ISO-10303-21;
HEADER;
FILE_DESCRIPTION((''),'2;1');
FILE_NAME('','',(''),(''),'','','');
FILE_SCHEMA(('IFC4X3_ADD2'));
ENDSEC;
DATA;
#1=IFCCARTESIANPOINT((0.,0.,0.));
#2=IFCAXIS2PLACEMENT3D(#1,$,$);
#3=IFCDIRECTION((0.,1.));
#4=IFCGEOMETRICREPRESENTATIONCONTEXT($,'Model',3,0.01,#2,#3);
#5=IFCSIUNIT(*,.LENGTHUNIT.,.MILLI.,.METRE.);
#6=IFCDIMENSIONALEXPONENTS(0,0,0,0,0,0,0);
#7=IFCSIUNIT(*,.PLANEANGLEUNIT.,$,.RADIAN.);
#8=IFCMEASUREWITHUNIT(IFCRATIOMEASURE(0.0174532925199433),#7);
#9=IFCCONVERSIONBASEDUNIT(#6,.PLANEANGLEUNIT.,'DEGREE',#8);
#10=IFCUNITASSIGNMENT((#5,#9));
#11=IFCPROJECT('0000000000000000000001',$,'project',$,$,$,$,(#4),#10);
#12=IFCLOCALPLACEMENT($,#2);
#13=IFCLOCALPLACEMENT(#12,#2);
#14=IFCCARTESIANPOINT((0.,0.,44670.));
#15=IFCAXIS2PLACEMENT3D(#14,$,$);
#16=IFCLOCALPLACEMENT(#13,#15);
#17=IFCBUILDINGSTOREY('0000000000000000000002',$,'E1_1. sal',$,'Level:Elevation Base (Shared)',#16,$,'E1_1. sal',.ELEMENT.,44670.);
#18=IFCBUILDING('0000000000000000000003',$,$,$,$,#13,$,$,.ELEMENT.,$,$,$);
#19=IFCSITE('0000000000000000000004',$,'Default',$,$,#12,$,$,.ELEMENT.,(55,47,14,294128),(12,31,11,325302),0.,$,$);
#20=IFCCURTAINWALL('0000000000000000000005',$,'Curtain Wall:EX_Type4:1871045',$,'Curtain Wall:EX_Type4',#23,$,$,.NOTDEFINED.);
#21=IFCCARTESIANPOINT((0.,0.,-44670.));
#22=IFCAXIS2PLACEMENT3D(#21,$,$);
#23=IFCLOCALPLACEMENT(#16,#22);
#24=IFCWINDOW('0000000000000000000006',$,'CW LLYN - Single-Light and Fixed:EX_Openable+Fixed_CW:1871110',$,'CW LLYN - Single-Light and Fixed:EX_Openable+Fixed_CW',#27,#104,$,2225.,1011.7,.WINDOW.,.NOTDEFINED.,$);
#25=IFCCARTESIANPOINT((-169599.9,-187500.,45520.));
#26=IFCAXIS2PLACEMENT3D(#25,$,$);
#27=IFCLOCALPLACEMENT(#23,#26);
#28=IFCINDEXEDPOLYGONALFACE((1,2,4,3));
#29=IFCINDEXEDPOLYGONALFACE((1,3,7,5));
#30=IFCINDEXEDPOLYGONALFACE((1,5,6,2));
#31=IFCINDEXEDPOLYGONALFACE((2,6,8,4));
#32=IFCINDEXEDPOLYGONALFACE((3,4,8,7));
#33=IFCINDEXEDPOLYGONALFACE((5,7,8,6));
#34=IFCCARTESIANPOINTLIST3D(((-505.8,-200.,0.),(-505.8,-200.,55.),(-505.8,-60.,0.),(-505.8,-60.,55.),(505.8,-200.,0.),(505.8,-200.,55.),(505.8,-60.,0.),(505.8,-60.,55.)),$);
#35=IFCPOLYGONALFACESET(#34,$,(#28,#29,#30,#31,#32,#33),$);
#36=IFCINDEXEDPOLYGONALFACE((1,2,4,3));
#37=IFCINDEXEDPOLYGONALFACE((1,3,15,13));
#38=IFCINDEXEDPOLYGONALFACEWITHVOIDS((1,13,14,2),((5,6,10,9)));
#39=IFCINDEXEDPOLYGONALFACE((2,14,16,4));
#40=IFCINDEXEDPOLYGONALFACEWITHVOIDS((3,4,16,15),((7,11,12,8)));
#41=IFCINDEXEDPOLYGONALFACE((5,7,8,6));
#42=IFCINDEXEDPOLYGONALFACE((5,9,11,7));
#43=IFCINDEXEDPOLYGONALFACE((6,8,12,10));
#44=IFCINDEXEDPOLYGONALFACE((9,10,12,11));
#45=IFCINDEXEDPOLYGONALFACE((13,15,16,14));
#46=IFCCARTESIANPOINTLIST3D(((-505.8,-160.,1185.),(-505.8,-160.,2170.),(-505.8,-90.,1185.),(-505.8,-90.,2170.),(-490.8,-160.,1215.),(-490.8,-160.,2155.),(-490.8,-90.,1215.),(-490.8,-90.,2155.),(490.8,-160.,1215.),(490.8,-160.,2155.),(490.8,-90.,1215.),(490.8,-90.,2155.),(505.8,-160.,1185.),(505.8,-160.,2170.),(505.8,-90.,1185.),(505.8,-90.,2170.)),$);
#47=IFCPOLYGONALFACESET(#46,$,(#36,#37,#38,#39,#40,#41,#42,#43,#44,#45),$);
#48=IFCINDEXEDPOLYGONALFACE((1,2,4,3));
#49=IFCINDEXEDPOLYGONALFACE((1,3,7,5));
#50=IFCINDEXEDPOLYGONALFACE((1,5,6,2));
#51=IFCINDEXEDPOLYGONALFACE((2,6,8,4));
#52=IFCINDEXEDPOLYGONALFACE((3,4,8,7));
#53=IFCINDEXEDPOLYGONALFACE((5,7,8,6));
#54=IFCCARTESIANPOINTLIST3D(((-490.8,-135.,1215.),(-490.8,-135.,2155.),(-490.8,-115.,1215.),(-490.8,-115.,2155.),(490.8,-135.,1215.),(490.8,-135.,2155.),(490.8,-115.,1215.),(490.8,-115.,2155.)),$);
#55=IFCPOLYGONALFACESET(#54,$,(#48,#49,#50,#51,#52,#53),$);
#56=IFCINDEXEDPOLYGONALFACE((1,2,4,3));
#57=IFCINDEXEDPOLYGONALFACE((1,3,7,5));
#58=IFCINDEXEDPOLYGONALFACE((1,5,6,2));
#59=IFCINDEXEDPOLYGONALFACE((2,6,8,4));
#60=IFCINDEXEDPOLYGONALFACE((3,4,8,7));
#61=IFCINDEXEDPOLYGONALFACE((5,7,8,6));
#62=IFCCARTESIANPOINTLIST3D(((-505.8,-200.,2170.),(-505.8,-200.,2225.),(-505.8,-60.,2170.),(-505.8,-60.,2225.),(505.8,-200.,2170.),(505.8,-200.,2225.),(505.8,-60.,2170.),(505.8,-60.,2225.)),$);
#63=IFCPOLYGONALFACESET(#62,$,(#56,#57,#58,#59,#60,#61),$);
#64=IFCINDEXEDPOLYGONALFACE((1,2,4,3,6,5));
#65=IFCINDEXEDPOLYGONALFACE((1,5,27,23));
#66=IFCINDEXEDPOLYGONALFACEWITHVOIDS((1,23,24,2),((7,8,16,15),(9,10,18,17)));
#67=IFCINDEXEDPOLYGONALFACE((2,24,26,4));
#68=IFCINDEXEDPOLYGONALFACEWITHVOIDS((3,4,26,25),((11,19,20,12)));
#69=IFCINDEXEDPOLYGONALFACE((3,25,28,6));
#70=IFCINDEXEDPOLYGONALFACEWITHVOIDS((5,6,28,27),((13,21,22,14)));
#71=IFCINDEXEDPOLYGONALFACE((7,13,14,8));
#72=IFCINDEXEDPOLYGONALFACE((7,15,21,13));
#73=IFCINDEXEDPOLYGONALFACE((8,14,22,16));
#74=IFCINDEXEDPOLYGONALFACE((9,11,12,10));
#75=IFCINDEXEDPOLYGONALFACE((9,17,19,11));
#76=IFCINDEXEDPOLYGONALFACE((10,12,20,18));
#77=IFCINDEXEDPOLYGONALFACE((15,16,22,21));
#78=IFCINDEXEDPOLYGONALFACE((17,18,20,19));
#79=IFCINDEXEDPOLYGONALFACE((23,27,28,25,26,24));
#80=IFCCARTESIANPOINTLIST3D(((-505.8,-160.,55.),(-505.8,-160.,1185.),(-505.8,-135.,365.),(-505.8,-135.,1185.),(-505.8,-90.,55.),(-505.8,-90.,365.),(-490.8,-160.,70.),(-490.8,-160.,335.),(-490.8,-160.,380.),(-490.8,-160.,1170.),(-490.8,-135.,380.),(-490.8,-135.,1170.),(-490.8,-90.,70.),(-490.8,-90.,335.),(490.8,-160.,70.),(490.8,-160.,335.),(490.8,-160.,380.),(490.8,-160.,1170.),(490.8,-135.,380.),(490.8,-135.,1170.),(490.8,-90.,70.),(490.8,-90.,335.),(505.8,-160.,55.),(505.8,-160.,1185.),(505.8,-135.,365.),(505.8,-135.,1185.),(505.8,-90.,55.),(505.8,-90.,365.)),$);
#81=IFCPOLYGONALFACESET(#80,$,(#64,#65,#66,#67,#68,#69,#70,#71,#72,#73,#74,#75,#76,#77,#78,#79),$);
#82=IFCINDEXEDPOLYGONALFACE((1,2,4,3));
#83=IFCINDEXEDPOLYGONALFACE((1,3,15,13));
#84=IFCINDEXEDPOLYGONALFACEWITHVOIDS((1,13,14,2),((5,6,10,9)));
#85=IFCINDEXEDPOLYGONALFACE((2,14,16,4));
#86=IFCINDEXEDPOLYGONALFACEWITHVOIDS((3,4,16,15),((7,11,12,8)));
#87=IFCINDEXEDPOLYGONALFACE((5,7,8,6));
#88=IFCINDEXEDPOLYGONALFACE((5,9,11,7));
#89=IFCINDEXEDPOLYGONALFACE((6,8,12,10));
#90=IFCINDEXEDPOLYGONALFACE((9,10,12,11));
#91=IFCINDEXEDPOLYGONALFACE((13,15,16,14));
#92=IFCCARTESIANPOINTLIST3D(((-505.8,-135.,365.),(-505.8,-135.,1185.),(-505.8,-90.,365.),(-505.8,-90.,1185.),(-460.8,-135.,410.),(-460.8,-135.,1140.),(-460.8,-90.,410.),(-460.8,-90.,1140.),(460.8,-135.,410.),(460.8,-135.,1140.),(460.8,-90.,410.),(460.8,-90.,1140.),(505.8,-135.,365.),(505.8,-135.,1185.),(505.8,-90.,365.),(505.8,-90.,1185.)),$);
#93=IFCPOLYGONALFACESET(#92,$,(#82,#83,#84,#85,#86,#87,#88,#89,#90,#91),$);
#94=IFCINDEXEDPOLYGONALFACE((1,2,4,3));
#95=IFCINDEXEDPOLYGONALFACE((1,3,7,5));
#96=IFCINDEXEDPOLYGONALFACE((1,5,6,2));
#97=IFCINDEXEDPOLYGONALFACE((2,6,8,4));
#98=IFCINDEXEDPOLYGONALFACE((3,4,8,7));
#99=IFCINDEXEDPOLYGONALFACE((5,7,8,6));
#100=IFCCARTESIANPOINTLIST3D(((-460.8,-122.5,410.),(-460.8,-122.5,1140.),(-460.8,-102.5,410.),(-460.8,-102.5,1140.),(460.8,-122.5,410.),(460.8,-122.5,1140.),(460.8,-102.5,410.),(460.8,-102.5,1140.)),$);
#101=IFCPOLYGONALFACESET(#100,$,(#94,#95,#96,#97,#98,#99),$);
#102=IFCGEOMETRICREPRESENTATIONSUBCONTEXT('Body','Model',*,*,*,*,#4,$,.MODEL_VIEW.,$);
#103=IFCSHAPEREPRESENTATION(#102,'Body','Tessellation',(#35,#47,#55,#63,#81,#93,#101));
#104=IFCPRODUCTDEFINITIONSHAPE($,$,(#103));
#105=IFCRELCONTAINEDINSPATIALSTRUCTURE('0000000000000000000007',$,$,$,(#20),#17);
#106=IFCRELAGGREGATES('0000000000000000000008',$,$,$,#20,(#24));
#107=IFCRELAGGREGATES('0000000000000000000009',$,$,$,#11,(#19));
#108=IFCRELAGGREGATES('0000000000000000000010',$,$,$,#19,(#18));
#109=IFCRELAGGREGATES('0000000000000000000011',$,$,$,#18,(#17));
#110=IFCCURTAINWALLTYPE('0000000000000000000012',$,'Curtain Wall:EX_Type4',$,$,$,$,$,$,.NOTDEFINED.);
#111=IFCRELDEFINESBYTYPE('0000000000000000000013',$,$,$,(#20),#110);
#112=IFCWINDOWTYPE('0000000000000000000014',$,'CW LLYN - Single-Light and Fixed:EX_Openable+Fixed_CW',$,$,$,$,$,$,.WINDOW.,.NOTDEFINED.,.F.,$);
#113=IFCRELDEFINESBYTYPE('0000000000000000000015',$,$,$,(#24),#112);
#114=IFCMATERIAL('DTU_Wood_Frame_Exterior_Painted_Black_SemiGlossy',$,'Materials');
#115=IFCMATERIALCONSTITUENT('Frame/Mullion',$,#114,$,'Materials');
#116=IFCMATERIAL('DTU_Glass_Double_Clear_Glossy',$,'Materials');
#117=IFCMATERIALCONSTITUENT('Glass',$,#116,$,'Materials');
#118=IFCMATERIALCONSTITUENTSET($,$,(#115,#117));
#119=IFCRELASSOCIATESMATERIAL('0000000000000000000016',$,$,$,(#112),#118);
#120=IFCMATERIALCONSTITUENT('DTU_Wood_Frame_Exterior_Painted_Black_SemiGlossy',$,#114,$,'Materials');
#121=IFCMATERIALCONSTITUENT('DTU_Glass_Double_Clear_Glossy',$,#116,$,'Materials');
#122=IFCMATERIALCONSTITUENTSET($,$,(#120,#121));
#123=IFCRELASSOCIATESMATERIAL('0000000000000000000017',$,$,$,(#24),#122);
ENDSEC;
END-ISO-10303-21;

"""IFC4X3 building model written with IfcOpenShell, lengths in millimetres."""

from ifc_helpers import new_model, entity, si_unit, converted_unit, direction, frame, frame_2d, origin, origin_2d_with_axis, place, context, subcontext, project, spatial, polyline, rectangle, outline, extrude, source, transform, mapped, material, constituent, constituent_set, type_object, type_shapes, element, aggregate, save


model = new_model("IFC4X3")

# Units and contexts
model_context = context("Model", 3, precision=0.01, world=origin(), true_north=direction((0.0, 1.0)))
body_context = subcontext(model_context, "Body", "Model", "MODEL_VIEW")
ifc_project = project(units=[si_unit("LENGTHUNIT", "METRE", prefix="MILLI"), converted_unit("PLANEANGLEUNIT", "DEGREE", entity("IfcRatioMeasure", 0.0174532925199433), si_unit("PLANEANGLEUNIT", "RADIAN"), dimensions=[0, 0, 0, 0, 0, 0, 0])], contexts=[model_context])

# Site, building, storey
site_placement = place(None, origin())
site = spatial("IfcSite", under=ifc_project, at=site_placement, Name="Default", CompositionType="ELEMENT", RefLatitude=(55, 47, 14, 294128), RefLongitude=(12, 31, 11, 325302), RefElevation=0.0)
building_placement = place(site_placement, origin())
building = spatial("IfcBuilding", under=site, at=building_placement, CompositionType="ELEMENT")
storey_placement = place(building_placement, frame((0.0, 0.0, 44670.0)))
storey = spatial("IfcBuildingStorey", under=building, at=storey_placement, Name="E1_1. sal", ObjectType="Level:Elevation Base (Shared)", LongName="E1_1. sal", CompositionType="ELEMENT", Elevation=44670.0)

# Curtain wall
curtain_wall_type = type_object("IfcCurtainWallType", Name="Curtain Wall:EX_Type4", PredefinedType="NOTDEFINED")
curtain_wall_placement = place(storey_placement, frame((0.0, 0.0, -44670.0)))
curtain_wall = element("IfcCurtainWall", 1, at=curtain_wall_placement, inside=storey, type_object=curtain_wall_type, Name="Curtain Wall:EX_Type4:1871045", ObjectType="Curtain Wall:EX_Type4", PredefinedType="NOTDEFINED")

# Shared definitions
ifc_material_1 = material(Name="DTU_Wood_Frame_Exterior_Painted_Black_SemiGlossy", Category="Materials")
ifc_material_2 = material(Name="DTU_Glass_Double_Clear_Glossy", Category="Materials")

# Window, openings
ifc_constituent_1 = constituent(ifc_material_1, Name="DTU_Wood_Frame_Exterior_Painted_Black_SemiGlossy", Category="Materials")
ifc_constituent_2 = constituent(ifc_material_2, Name="DTU_Glass_Double_Clear_Glossy", Category="Materials")
ifc_constituent_set_1 = constituent_set(constituents=[ifc_constituent_1, ifc_constituent_2])
ifc_constituent_3 = constituent(ifc_material_1, Name="Frame/Mullion", Category="Materials")
ifc_constituent_4 = constituent(ifc_material_2, Name="Glass", Category="Materials")
ifc_constituent_set_2 = constituent_set(constituents=[ifc_constituent_3, ifc_constituent_4])
window_type_1 = type_object("IfcWindowType", Name="CW LLYN - Single-Light and Fixed:EX_Openable+Fixed_CW", ParameterTakesPrecedence=False, PartitioningType="NOTDEFINED", PredefinedType="WINDOW", material=ifc_constituent_set_2)
shared_shape_1 = source(origin(), body_context, "Body", "SweptSolid", [
    extrude(rectangle(XDim=140.0, YDim=1011.7, at=origin_2d_with_axis()), frame((0.0, -130.0, 0.0), z_axis=(0.0, 0.0, 1.0), x_axis=(0.0, -1.0, 0.0)), (0.0, 0.0, 1.0), 55.0),
    extrude(outline(polyline([(-492.5, -505.8), (492.5, -505.8), (492.5, 505.8), (-492.5, 505.8), (-492.5, -505.8)]), holes=[polyline([(477.5, -490.8), (-462.5, -490.8), (-462.5, 490.8), (477.5, 490.8), (477.5, -490.8)])]), frame((0.0, -90.0, 1677.5), z_axis=(0.0, -1.0, 0.0), x_axis=(0.0, 0.0, 1.0)), (0.0, 0.0, 1.0), 70.0),
    extrude(rectangle(XDim=981.7, YDim=20.0, at=frame_2d((0.0, 0.0), x_axis=(1.0, 0.0))), frame((0.0, -125.0, 1215.0), z_axis=(0.0, 0.0, 1.0), x_axis=(-1.0, 0.0, 0.0)), (0.0, 0.0, 1.0), 940.0),
    extrude(rectangle(XDim=981.7, YDim=20.0, at=frame_2d((0.0, 0.0), x_axis=(1.0, 0.0))), frame((0.0, -125.0, 70.0), z_axis=(0.0, 0.0, 1.0), x_axis=(-1.0, 0.0, 0.0)), (0.0, 0.0, 1.0), 265.0),
    extrude(rectangle(XDim=140.0, YDim=1011.7, at=frame_2d((0.0, 0.0), x_axis=(1.0, 0.0))), frame((0.0, -130.0, 2170.0), z_axis=(0.0, 0.0, 1.0), x_axis=(0.0, -1.0, 0.0)), (0.0, 0.0, 1.0), 55.0),
    extrude(outline(polyline([(-38.3, -480.0), (31.7, -480.0), (31.7, 650.0), (6.7, 650.0), (6.7, -170.0), (-38.3, -170.0), (-38.3, -480.0)])), frame((505.8, -128.3, 535.0), z_axis=(-1.0, 0.0, 0.0), x_axis=(0.0, -1.0, 0.0)), (0.0, 0.0, 1.0), 1011.7),
    extrude(outline(polyline([(-410.0, -505.8), (410.0, -505.8), (410.0, 505.8), (-410.0, 505.8), (-410.0, -505.8)]), holes=[polyline([(-365.0, 460.8), (365.0, 460.8), (365.0, -460.8), (-365.0, -460.8), (-365.0, 460.8)])]), frame((0.0, -90.0, 775.0), z_axis=(0.0, -1.0, 0.0), x_axis=(0.0, 0.0, 1.0)), (0.0, 0.0, 1.0), 45.0),
    extrude(rectangle(XDim=921.7, YDim=20.0, at=frame_2d((0.0, 0.0), x_axis=(1.0, 0.0))), frame((0.0, -112.5, 410.0), z_axis=(0.0, 0.0, 1.0), x_axis=(-1.0, 0.0, 0.0)), (0.0, 0.0, 1.0), 730.0),
])
type_shapes(window_type_1, [shared_shape_1])
window_1_placement = place(curtain_wall_placement, frame((-169599.9, -187500.0, 45520.0)))
window_1 = element("IfcWindow", 2, at=window_1_placement, type_object=window_type_1, material=ifc_constituent_set_1, Name="CW LLYN - Single-Light and Fixed:EX_Openable+Fixed_CW:1871110", ObjectType="CW LLYN - Single-Light and Fixed:EX_Openable+Fixed_CW", OverallHeight=2225.0, OverallWidth=1011.7, PartitioningType="NOTDEFINED", PredefinedType="WINDOW", context=body_context, shape_type="MappedRepresentation", body=[
    mapped(shared_shape_1, transform((0.0, 0.0, 0.0), scale=1.0)),
])
opening_1_placement = place(curtain_wall_placement, frame((-169599.9, -187500.0, 90190.0), z_axis=(0.0, 0.0, 1.0), x_axis=(-1.0, 0.0, 0.0)))
opening_1 = element("IfcOpeningElement", 3, at=opening_1_placement, cuts=window_1, PredefinedType="OPENING", context=body_context, shape_type="SweptSolid", body=[
    extrude(rectangle(XDim=265.0, YDim=981.7, at=frame_2d((0.0, 0.0), x_axis=(1.0, 0.0))), frame((0.0, 160.0, -44467.5), z_axis=(0.0, -1.0, 0.0), x_axis=(0.0, 0.0, 1.0)), (0.0, 0.0, 1.0), 70.0),
])
opening_2_placement = place(curtain_wall_placement, frame((-169599.9, -187500.0, 90190.0), z_axis=(0.0, 0.0, 1.0), x_axis=(-1.0, 0.0, 0.0)))
opening_2 = element("IfcOpeningElement", 4, at=opening_2_placement, cuts=window_1, PredefinedType="OPENING", context=body_context, shape_type="SweptSolid", body=[
    extrude(rectangle(XDim=790.0, YDim=981.7, at=frame_2d((0.0, 0.0), x_axis=(1.0, 0.0))), frame((0.0, 135.0, -43895.0), z_axis=(0.0, 1.0, 0.0), x_axis=(0.0, 0.0, 1.0)), (0.0, 0.0, 1.0), 25.0),
])
aggregate(curtain_wall, [window_1, opening_1, opening_2])

save(model, "model.ifc")
